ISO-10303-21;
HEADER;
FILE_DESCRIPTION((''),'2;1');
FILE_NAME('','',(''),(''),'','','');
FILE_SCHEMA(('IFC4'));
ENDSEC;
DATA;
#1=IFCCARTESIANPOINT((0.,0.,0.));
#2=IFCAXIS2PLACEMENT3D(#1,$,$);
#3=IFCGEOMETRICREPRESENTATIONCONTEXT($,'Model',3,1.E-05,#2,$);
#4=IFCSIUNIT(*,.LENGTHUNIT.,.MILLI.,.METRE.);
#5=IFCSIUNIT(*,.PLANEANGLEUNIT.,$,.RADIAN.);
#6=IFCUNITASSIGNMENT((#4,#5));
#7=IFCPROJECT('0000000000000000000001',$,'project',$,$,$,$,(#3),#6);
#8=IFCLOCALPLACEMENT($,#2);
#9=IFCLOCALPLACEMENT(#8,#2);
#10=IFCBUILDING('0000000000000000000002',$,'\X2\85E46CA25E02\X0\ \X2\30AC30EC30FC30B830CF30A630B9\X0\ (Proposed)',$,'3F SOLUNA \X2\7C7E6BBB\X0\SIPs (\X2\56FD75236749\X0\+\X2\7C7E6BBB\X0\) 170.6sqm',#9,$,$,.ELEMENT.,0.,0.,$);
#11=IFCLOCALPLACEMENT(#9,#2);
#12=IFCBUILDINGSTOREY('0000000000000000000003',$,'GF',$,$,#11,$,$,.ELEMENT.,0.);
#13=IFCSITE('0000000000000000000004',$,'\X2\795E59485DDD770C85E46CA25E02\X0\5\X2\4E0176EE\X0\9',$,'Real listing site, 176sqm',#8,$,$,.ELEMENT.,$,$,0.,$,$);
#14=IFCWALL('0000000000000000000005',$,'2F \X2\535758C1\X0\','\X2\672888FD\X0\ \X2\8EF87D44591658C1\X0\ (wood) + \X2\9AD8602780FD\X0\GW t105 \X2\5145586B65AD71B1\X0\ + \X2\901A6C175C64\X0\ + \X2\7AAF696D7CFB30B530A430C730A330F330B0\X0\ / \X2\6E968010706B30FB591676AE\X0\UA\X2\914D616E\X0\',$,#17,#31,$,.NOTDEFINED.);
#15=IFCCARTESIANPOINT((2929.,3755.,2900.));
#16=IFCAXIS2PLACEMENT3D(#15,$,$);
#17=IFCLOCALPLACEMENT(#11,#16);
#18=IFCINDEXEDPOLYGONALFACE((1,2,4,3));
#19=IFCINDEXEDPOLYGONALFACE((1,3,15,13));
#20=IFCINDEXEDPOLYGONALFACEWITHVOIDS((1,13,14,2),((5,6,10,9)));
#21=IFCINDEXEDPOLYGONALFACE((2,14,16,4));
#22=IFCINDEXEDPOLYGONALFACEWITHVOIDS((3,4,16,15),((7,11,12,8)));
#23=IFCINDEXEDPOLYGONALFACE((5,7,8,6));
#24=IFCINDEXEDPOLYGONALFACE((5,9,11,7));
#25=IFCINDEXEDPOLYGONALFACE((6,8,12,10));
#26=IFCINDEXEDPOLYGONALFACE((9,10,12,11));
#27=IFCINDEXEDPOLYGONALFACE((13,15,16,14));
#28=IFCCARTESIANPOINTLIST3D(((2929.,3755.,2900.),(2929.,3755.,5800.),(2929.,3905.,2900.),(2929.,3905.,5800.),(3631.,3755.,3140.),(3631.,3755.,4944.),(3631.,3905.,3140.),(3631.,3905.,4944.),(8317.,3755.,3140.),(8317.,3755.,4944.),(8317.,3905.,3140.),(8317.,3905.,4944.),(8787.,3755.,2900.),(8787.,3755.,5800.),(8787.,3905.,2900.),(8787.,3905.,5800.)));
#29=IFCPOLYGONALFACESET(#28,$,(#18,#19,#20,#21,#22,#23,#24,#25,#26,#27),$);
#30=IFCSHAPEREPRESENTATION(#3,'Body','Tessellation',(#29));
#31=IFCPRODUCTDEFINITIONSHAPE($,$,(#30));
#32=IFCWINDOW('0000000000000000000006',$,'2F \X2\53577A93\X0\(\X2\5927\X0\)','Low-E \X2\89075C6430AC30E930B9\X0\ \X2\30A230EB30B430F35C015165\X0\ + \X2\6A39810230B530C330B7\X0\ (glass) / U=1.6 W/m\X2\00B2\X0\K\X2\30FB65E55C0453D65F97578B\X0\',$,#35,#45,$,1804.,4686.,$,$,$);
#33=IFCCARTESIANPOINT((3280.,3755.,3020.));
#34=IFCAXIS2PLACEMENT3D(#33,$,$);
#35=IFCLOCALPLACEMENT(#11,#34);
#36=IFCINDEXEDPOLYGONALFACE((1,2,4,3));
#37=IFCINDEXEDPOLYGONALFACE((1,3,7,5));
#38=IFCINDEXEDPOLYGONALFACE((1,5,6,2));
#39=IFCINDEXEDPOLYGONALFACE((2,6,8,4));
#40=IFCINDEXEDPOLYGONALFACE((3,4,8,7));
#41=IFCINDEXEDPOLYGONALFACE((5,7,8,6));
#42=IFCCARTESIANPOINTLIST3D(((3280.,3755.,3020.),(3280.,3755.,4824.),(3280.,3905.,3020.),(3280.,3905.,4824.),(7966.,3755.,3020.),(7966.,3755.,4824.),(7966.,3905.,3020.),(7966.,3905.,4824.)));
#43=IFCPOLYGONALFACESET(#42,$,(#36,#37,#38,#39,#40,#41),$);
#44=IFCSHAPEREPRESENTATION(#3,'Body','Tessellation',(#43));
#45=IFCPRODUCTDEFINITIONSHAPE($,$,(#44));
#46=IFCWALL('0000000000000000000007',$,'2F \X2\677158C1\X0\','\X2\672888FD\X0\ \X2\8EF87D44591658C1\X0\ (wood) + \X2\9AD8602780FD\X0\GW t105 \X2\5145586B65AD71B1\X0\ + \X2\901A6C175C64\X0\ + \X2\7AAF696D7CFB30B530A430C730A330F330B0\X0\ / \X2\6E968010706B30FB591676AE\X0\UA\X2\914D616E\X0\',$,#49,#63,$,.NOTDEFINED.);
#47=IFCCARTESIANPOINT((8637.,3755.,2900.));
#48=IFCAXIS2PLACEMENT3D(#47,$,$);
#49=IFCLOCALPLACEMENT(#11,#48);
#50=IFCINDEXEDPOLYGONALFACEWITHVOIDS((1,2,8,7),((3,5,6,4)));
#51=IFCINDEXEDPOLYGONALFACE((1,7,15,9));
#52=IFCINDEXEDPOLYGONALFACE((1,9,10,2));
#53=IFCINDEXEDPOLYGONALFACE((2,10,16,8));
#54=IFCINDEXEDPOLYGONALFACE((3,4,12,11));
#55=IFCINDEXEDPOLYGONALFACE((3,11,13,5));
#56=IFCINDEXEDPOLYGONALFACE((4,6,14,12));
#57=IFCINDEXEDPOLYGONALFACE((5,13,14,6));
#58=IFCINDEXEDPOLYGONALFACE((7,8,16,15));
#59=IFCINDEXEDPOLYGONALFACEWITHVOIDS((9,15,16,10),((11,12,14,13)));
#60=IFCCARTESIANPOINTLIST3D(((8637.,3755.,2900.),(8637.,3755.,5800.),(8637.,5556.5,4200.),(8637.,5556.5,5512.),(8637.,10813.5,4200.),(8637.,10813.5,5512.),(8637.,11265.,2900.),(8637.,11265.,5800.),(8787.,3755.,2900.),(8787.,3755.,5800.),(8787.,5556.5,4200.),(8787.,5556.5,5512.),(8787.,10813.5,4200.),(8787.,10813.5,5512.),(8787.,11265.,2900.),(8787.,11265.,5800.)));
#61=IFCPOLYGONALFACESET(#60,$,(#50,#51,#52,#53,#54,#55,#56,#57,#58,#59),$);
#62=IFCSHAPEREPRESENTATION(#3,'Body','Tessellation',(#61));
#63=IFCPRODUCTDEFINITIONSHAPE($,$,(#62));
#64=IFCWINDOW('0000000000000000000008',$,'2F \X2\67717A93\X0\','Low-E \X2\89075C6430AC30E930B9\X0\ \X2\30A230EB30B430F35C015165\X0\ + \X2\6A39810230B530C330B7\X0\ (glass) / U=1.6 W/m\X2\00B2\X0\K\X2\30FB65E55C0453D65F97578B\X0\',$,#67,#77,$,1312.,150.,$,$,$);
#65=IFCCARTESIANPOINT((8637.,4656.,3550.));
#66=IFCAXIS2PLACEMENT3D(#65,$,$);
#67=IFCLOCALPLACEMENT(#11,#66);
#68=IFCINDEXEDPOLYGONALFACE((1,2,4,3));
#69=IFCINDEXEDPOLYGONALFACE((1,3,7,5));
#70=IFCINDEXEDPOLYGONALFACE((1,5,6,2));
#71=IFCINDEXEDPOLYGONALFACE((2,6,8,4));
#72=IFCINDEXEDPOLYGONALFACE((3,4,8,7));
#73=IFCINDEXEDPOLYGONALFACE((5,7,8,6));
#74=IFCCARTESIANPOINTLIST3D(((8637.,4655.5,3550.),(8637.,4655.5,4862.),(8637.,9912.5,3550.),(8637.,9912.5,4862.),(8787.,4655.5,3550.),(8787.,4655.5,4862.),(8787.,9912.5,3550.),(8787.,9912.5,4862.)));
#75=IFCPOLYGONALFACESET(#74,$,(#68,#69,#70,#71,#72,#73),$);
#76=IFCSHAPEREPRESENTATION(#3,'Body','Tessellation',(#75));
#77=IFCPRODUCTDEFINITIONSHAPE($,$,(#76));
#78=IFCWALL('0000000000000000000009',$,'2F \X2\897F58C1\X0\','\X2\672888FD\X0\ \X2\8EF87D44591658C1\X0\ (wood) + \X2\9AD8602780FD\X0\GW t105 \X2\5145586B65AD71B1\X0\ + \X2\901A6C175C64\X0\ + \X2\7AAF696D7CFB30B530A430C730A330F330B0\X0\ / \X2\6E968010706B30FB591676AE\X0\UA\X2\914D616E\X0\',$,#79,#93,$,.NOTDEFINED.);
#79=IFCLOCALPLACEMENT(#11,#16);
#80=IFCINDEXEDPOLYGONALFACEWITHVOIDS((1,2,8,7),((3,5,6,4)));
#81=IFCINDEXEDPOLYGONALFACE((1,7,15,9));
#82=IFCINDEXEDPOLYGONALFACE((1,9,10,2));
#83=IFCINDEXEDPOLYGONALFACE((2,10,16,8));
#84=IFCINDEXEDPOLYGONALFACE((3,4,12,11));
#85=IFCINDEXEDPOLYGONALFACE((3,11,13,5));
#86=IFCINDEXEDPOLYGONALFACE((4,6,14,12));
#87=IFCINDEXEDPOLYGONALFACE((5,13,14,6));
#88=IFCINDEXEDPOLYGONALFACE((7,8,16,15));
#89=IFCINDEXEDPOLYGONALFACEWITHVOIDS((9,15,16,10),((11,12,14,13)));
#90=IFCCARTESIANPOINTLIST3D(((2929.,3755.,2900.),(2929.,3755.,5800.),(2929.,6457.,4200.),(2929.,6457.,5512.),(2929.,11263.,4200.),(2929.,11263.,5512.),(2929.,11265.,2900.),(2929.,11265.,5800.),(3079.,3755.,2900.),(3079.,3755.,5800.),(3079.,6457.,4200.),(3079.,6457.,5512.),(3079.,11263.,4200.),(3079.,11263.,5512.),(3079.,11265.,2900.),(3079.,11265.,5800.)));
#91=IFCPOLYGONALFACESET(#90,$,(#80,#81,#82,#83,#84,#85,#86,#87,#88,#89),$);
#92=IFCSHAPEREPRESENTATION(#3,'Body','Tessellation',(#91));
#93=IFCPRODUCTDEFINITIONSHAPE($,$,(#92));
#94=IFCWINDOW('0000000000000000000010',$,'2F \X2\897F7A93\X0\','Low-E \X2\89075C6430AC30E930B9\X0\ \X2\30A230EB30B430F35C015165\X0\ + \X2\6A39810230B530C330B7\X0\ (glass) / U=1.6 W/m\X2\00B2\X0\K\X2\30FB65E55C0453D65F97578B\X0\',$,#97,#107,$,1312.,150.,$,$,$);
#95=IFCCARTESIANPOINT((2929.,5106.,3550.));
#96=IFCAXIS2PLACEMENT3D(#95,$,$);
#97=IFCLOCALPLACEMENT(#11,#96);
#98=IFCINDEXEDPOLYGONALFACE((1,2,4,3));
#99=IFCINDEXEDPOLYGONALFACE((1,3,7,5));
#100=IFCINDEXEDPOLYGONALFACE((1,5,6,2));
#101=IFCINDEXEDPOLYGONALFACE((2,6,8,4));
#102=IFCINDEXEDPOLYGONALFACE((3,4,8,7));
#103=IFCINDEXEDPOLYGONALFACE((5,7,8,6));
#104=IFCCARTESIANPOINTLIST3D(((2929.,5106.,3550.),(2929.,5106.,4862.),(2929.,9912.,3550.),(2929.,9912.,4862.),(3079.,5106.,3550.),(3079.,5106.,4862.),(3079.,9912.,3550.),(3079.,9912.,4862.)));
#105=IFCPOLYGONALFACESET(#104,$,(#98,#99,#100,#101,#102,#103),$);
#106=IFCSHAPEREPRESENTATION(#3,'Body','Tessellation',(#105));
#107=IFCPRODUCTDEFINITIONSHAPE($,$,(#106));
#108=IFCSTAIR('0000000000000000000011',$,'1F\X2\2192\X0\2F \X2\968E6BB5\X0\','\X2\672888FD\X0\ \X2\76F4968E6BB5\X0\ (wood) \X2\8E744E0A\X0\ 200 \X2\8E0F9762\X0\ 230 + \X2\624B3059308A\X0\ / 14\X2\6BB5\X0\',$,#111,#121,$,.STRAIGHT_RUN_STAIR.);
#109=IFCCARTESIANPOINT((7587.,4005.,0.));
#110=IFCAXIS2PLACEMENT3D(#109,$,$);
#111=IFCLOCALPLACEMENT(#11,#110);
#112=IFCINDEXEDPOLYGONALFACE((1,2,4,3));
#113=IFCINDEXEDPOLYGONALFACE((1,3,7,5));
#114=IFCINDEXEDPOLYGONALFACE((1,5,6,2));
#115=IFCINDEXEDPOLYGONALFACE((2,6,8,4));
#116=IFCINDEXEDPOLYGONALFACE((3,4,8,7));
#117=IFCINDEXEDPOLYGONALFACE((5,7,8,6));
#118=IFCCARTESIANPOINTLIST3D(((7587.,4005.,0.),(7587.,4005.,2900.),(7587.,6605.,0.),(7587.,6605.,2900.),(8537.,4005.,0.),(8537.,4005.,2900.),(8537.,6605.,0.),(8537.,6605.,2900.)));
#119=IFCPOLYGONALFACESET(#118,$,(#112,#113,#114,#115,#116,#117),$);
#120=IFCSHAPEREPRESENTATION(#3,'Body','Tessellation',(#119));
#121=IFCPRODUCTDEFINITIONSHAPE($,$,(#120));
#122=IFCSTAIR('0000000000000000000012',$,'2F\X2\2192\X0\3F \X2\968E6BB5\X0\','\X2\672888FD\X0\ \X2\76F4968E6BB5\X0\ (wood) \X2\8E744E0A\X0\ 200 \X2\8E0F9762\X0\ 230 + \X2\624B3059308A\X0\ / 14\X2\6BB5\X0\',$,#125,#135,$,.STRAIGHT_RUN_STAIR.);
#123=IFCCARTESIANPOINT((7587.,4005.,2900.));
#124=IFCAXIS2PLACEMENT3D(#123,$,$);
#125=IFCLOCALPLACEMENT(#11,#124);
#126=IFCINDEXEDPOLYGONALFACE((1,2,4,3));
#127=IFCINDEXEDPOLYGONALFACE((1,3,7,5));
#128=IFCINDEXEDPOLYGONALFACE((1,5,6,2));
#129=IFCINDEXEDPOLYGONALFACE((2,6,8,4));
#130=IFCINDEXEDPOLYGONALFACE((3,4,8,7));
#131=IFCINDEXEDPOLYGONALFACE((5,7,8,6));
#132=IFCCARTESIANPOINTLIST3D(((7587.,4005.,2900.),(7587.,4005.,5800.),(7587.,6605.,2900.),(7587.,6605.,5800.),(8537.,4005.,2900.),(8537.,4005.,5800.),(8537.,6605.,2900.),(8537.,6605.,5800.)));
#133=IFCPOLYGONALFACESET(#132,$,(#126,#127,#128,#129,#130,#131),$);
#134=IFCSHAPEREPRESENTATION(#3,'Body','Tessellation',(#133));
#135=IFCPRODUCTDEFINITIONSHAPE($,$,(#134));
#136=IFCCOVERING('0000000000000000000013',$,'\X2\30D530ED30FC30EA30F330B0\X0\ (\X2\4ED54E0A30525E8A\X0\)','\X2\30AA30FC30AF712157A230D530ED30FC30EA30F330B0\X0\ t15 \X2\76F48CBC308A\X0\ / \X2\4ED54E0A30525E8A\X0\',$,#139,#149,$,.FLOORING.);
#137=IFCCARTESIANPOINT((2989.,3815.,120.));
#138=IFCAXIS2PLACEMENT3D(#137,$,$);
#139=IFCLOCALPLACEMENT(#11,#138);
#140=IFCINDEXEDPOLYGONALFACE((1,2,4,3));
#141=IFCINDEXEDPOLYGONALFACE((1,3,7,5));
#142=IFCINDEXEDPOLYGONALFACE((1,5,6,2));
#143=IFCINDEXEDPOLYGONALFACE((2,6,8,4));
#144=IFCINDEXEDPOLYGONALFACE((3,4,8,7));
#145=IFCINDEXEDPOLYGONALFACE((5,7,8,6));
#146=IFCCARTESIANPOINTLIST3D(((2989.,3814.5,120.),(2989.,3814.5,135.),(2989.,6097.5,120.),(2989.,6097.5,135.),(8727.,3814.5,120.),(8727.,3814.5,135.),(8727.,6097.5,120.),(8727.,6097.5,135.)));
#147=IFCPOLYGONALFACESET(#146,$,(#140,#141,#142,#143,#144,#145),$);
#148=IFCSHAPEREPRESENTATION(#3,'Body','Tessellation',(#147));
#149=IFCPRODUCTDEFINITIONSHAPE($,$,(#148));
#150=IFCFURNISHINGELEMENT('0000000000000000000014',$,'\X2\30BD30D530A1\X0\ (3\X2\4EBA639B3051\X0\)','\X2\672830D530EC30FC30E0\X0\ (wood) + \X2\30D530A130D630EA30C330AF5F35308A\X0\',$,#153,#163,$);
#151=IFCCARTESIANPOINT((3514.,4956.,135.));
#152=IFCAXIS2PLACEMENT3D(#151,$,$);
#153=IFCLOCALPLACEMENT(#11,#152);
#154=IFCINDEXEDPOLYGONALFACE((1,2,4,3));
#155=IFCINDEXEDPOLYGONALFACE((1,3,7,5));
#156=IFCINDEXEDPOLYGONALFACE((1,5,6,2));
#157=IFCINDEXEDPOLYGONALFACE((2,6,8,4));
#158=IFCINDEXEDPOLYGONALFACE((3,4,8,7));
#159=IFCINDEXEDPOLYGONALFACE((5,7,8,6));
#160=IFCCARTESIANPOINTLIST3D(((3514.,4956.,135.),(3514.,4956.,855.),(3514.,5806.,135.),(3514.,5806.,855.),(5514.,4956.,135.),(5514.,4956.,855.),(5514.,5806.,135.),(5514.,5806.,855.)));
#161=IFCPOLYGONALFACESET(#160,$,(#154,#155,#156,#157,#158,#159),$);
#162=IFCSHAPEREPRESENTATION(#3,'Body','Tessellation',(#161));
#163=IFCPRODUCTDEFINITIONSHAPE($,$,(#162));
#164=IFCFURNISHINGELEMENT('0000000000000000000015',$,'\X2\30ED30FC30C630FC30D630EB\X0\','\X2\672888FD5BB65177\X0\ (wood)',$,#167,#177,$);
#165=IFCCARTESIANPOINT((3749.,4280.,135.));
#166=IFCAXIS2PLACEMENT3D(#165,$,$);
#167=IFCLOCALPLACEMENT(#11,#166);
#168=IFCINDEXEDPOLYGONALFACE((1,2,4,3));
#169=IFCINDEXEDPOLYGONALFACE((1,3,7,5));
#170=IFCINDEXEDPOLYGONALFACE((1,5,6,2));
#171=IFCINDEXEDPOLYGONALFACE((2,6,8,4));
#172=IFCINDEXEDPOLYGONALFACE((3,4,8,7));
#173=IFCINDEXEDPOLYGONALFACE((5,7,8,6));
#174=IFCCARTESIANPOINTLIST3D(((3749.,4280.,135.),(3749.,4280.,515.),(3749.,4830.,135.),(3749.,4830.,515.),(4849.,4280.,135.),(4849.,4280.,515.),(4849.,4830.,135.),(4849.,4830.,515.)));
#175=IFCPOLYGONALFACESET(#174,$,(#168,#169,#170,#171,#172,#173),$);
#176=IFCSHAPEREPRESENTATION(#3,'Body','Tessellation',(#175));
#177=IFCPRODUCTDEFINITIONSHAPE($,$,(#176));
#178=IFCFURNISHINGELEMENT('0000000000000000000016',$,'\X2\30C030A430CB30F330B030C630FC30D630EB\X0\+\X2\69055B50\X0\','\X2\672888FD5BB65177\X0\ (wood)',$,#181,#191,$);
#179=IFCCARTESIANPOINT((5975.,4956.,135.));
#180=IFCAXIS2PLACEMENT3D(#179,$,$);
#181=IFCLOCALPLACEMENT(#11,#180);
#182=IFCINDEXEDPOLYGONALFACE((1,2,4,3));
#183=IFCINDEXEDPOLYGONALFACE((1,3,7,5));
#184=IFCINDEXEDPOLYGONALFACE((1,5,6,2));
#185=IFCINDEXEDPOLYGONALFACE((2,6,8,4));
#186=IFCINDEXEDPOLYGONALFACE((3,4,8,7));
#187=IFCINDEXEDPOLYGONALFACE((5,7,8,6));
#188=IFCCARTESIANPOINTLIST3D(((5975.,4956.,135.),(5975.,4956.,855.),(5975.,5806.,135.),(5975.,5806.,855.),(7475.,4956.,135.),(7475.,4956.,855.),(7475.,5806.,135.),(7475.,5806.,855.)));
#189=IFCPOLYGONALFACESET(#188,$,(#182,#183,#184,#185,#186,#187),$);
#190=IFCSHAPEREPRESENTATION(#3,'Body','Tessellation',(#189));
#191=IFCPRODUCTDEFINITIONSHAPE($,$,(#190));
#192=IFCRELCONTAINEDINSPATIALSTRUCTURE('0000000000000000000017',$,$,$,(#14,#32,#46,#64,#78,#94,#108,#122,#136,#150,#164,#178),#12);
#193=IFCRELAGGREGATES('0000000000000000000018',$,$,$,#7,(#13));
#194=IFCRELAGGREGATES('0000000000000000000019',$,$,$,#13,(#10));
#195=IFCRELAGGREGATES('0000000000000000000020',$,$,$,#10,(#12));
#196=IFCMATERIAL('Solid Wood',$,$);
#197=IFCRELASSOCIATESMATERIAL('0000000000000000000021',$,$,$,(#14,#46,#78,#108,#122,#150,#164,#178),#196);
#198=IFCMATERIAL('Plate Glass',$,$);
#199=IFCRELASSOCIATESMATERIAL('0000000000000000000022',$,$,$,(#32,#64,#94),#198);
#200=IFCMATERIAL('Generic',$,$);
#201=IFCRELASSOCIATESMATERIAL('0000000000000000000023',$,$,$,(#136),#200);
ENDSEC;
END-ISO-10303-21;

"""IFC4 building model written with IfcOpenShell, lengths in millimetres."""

from ifc_helpers import new_model, si_unit, frame, frame_2d, origin, place, context, project, spatial, rectangle, extrude, material, element, fill, save


model = new_model("IFC4")

# Units and contexts
model_context = context("Model", 3, precision=1e-05, world=origin())
ifc_project = project(units=[si_unit("LENGTHUNIT", "METRE", prefix="MILLI"), si_unit("PLANEANGLEUNIT", "RADIAN")], contexts=[model_context])

# Site, building, storey
site_placement = place(None, origin())
site = spatial("IfcSite", under=ifc_project, at=site_placement, Name="神奈川県藤沢市5丁目9", ObjectType="Real listing site, 176sqm", CompositionType="ELEMENT", RefElevation=0.0)
building_placement = place(site_placement, origin())
building = spatial("IfcBuilding", under=site, at=building_placement, Name="藤沢市 ガレージハウス (Proposed)", ObjectType="3F SOLUNA 籾殻SIPs (国産杉+籾殻) 170.6sqm", CompositionType="ELEMENT", ElevationOfRefHeight=0.0, ElevationOfTerrain=0.0)
storey_placement = place(building_placement, origin())
storey = spatial("IfcBuildingStorey", under=building, at=storey_placement, Name="GF", CompositionType="ELEMENT", Elevation=0.0)

# Shared definitions
ifc_material_1 = material(Name="Solid Wood")
ifc_material_2 = material(Name="Generic")

# Shared definitions
ifc_material_3 = material(Name="Plate Glass")

# Walls, openings, windows
wall_1_placement = place(storey_placement, frame((2929.0, 3755.0, 2900.0)))
wall_1 = element("IfcWall", 1, at=wall_1_placement, inside=storey, material=ifc_material_1, Name="2F 南壁", Description="木製 軸組外壁 (wood) + 高性能GW t105 充填断熱 + 通気層 + 窯業系サイディング / 準耐火・外皮UA配慮", PredefinedType="NOTDEFINED", context=model_context, shape_type="SweptSolid", body=[
    extrude(rectangle(XDim=5858.0, YDim=150.0, at=frame_2d((2929.0, 75.0))), frame((2929.0, 3755.0, 2900.0)), (0.0, 0.0, 1.0), 2900.0),
])
opening_1_placement = place(storey_placement, frame((3280.0, 3755.0, 3020.0)))
opening_1 = element("IfcOpeningElement", 2, at=opening_1_placement, cuts=wall_1, PredefinedType="NOTDEFINED", context=model_context, shape_type="SweptSolid", body=[
    extrude(rectangle(XDim=4686.0, YDim=150.0, at=frame_2d((2343.0, 75.0))), frame((3280.0, 3755.0, 3020.0)), (0.0, 0.0, 1.0), 1804.0),
])
window_1_placement = place(storey_placement, frame((3280.0, 3755.0, 3020.0)))
window_1 = element("IfcWindow", 3, at=window_1_placement, inside=storey, material=ifc_material_3, Name="2F 南窓(大)", Description="Low-E 複層ガラス アルゴン封入 + 樹脂サッシ (glass) / U=1.6 W/m²K・日射取得型", OverallHeight=1804.0, OverallWidth=4686.0, context=model_context, shape_type="SweptSolid", body=[
    extrude(rectangle(XDim=4686.0, YDim=150.0, at=frame_2d((2343.0, 75.0))), frame((3280.0, 3755.0, 3020.0)), (0.0, 0.0, 1.0), 1804.0),
])
fill(opening_1, window_1)
wall_2_placement = place(storey_placement, frame((8637.0, 3755.0, 2900.0)))
wall_2 = element("IfcWall", 4, at=wall_2_placement, inside=storey, material=ifc_material_1, Name="2F 東壁", Description="木製 軸組外壁 (wood) + 高性能GW t105 充填断熱 + 通気層 + 窯業系サイディング / 準耐火・外皮UA配慮", PredefinedType="NOTDEFINED", context=model_context, shape_type="SweptSolid", body=[
    extrude(rectangle(XDim=150.0, YDim=7510.0, at=frame_2d((75.0, 3755.0))), frame((8637.0, 3755.0, 2900.0)), (0.0, 0.0, 1.0), 2900.0),
])
opening_2_placement = place(storey_placement, frame((8637.0, 4656.0, 3550.0)))
opening_2 = element("IfcOpeningElement", 5, at=opening_2_placement, cuts=wall_2, PredefinedType="NOTDEFINED", context=model_context, shape_type="SweptSolid", body=[
    extrude(rectangle(XDim=150.0, YDim=5257.0, at=frame_2d((75.0, 2628.0))), frame((8637.0, 4656.0, 3550.0)), (0.0, 0.0, 1.0), 1312.0),
])
window_2_placement = place(storey_placement, frame((8637.0, 4656.0, 3550.0)))
window_2 = element("IfcWindow", 6, at=window_2_placement, inside=storey, material=ifc_material_3, Name="2F 東窓", Description="Low-E 複層ガラス アルゴン封入 + 樹脂サッシ (glass) / U=1.6 W/m²K・日射取得型", OverallHeight=1312.0, OverallWidth=150.0, context=model_context, shape_type="SweptSolid", body=[
    extrude(rectangle(XDim=150.0, YDim=5257.0, at=frame_2d((75.0, 2628.0))), frame((8637.0, 4656.0, 3550.0)), (0.0, 0.0, 1.0), 1312.0),
])
fill(opening_2, window_2)
wall_3_placement = place(storey_placement, frame((2929.0, 3755.0, 2900.0)))
wall_3 = element("IfcWall", 7, at=wall_3_placement, inside=storey, material=ifc_material_1, Name="2F 西壁", Description="木製 軸組外壁 (wood) + 高性能GW t105 充填断熱 + 通気層 + 窯業系サイディング / 準耐火・外皮UA配慮", PredefinedType="NOTDEFINED", context=model_context, shape_type="SweptSolid", body=[
    extrude(rectangle(XDim=150.0, YDim=7510.0, at=frame_2d((75.0, 3755.0))), frame((2929.0, 3755.0, 2900.0)), (0.0, 0.0, 1.0), 2900.0),
])
opening_3_placement = place(storey_placement, frame((2929.0, 5106.0, 3550.0)))
opening_3 = element("IfcOpeningElement", 8, at=opening_3_placement, cuts=wall_3, PredefinedType="NOTDEFINED", context=model_context, shape_type="SweptSolid", body=[
    extrude(rectangle(XDim=150.0, YDim=4806.0, at=frame_2d((75.0, 2403.0))), frame((2929.0, 5106.0, 3550.0)), (0.0, 0.0, 1.0), 1312.0),
])
window_3_placement = place(storey_placement, frame((2929.0, 5106.0, 3550.0)))
window_3 = element("IfcWindow", 9, at=window_3_placement, inside=storey, material=ifc_material_3, Name="2F 西窓", Description="Low-E 複層ガラス アルゴン封入 + 樹脂サッシ (glass) / U=1.6 W/m²K・日射取得型", OverallHeight=1312.0, OverallWidth=150.0, context=model_context, shape_type="SweptSolid", body=[
    extrude(rectangle(XDim=150.0, YDim=4806.0, at=frame_2d((75.0, 2403.0))), frame((2929.0, 5106.0, 3550.0)), (0.0, 0.0, 1.0), 1312.0),
])
fill(opening_3, window_3)

# Stairs
stair_1_placement = place(storey_placement, frame((7587.0, 4005.0, 0.0)))
element("IfcStair", 10, at=stair_1_placement, inside=storey, material=ifc_material_1, Name="1F→2F 階段", Description="木製 直階段 (wood) 蹴上 200 踏面 230 + 手すり / 14段", PredefinedType="STRAIGHT_RUN_STAIR", context=model_context, shape_type="SweptSolid", body=[
    extrude(rectangle(XDim=950.0, YDim=2600.0, at=frame_2d((475.0, 1300.0))), frame((7587.0, 4005.0, 0.0)), (0.0, 0.0, 1.0), 2900.0),
])
stair_2_placement = place(storey_placement, frame((7587.0, 4005.0, 2900.0)))
element("IfcStair", 11, at=stair_2_placement, inside=storey, material=ifc_material_1, Name="2F→3F 階段", Description="木製 直階段 (wood) 蹴上 200 踏面 230 + 手すり / 14段", PredefinedType="STRAIGHT_RUN_STAIR", context=model_context, shape_type="SweptSolid", body=[
    extrude(rectangle(XDim=950.0, YDim=2600.0, at=frame_2d((475.0, 1300.0))), frame((7587.0, 4005.0, 2900.0)), (0.0, 0.0, 1.0), 2900.0),
])

# Covering
covering_placement = place(storey_placement, frame((2989.0, 3815.0, 120.0)))
element("IfcCovering", 12, at=covering_placement, inside=storey, material=ifc_material_2, Name="フローリング (仕上げ床)", Description="オーク無垢フローリング t15 直貼り / 仕上げ床", PredefinedType="FLOORING", context=model_context, shape_type="SweptSolid", body=[
    extrude(rectangle(XDim=5738.0, YDim=2283.0, at=frame_2d((2869.0, 1141.0))), frame((2989.0, 3815.0, 120.0)), (0.0, 0.0, 1.0), 15.0),
])

# Furnishing elements
furnishing_1_placement = place(storey_placement, frame((3514.0, 4956.0, 135.0)))
element("IfcFurnishingElement", 13, at=furnishing_1_placement, inside=storey, material=ifc_material_1, Name="ソファ (3人掛け)", Description="木フレーム (wood) + ファブリック張り", context=model_context, shape_type="SweptSolid", body=[
    extrude(rectangle(XDim=2000.0, YDim=850.0, at=frame_2d((1000.0, 425.0))), frame((3514.0, 4956.0, 135.0)), (0.0, 0.0, 1.0), 720.0),
])
furnishing_2_placement = place(storey_placement, frame((3749.0, 4280.0, 135.0)))
element("IfcFurnishingElement", 14, at=furnishing_2_placement, inside=storey, material=ifc_material_1, Name="ローテーブル", Description="木製家具 (wood)", context=model_context, shape_type="SweptSolid", body=[
    extrude(rectangle(XDim=1100.0, YDim=550.0, at=frame_2d((550.0, 275.0))), frame((3749.0, 4280.0, 135.0)), (0.0, 0.0, 1.0), 380.0),
])
furnishing_3_placement = place(storey_placement, frame((5975.0, 4956.0, 135.0)))
element("IfcFurnishingElement", 15, at=furnishing_3_placement, inside=storey, material=ifc_material_1, Name="ダイニングテーブル+椅子", Description="木製家具 (wood)", context=model_context, shape_type="SweptSolid", body=[
    extrude(rectangle(XDim=1500.0, YDim=850.0, at=frame_2d((750.0, 425.0))), frame((5975.0, 4956.0, 135.0)), (0.0, 0.0, 1.0), 720.0),
])

save(model, "model.ifc")
